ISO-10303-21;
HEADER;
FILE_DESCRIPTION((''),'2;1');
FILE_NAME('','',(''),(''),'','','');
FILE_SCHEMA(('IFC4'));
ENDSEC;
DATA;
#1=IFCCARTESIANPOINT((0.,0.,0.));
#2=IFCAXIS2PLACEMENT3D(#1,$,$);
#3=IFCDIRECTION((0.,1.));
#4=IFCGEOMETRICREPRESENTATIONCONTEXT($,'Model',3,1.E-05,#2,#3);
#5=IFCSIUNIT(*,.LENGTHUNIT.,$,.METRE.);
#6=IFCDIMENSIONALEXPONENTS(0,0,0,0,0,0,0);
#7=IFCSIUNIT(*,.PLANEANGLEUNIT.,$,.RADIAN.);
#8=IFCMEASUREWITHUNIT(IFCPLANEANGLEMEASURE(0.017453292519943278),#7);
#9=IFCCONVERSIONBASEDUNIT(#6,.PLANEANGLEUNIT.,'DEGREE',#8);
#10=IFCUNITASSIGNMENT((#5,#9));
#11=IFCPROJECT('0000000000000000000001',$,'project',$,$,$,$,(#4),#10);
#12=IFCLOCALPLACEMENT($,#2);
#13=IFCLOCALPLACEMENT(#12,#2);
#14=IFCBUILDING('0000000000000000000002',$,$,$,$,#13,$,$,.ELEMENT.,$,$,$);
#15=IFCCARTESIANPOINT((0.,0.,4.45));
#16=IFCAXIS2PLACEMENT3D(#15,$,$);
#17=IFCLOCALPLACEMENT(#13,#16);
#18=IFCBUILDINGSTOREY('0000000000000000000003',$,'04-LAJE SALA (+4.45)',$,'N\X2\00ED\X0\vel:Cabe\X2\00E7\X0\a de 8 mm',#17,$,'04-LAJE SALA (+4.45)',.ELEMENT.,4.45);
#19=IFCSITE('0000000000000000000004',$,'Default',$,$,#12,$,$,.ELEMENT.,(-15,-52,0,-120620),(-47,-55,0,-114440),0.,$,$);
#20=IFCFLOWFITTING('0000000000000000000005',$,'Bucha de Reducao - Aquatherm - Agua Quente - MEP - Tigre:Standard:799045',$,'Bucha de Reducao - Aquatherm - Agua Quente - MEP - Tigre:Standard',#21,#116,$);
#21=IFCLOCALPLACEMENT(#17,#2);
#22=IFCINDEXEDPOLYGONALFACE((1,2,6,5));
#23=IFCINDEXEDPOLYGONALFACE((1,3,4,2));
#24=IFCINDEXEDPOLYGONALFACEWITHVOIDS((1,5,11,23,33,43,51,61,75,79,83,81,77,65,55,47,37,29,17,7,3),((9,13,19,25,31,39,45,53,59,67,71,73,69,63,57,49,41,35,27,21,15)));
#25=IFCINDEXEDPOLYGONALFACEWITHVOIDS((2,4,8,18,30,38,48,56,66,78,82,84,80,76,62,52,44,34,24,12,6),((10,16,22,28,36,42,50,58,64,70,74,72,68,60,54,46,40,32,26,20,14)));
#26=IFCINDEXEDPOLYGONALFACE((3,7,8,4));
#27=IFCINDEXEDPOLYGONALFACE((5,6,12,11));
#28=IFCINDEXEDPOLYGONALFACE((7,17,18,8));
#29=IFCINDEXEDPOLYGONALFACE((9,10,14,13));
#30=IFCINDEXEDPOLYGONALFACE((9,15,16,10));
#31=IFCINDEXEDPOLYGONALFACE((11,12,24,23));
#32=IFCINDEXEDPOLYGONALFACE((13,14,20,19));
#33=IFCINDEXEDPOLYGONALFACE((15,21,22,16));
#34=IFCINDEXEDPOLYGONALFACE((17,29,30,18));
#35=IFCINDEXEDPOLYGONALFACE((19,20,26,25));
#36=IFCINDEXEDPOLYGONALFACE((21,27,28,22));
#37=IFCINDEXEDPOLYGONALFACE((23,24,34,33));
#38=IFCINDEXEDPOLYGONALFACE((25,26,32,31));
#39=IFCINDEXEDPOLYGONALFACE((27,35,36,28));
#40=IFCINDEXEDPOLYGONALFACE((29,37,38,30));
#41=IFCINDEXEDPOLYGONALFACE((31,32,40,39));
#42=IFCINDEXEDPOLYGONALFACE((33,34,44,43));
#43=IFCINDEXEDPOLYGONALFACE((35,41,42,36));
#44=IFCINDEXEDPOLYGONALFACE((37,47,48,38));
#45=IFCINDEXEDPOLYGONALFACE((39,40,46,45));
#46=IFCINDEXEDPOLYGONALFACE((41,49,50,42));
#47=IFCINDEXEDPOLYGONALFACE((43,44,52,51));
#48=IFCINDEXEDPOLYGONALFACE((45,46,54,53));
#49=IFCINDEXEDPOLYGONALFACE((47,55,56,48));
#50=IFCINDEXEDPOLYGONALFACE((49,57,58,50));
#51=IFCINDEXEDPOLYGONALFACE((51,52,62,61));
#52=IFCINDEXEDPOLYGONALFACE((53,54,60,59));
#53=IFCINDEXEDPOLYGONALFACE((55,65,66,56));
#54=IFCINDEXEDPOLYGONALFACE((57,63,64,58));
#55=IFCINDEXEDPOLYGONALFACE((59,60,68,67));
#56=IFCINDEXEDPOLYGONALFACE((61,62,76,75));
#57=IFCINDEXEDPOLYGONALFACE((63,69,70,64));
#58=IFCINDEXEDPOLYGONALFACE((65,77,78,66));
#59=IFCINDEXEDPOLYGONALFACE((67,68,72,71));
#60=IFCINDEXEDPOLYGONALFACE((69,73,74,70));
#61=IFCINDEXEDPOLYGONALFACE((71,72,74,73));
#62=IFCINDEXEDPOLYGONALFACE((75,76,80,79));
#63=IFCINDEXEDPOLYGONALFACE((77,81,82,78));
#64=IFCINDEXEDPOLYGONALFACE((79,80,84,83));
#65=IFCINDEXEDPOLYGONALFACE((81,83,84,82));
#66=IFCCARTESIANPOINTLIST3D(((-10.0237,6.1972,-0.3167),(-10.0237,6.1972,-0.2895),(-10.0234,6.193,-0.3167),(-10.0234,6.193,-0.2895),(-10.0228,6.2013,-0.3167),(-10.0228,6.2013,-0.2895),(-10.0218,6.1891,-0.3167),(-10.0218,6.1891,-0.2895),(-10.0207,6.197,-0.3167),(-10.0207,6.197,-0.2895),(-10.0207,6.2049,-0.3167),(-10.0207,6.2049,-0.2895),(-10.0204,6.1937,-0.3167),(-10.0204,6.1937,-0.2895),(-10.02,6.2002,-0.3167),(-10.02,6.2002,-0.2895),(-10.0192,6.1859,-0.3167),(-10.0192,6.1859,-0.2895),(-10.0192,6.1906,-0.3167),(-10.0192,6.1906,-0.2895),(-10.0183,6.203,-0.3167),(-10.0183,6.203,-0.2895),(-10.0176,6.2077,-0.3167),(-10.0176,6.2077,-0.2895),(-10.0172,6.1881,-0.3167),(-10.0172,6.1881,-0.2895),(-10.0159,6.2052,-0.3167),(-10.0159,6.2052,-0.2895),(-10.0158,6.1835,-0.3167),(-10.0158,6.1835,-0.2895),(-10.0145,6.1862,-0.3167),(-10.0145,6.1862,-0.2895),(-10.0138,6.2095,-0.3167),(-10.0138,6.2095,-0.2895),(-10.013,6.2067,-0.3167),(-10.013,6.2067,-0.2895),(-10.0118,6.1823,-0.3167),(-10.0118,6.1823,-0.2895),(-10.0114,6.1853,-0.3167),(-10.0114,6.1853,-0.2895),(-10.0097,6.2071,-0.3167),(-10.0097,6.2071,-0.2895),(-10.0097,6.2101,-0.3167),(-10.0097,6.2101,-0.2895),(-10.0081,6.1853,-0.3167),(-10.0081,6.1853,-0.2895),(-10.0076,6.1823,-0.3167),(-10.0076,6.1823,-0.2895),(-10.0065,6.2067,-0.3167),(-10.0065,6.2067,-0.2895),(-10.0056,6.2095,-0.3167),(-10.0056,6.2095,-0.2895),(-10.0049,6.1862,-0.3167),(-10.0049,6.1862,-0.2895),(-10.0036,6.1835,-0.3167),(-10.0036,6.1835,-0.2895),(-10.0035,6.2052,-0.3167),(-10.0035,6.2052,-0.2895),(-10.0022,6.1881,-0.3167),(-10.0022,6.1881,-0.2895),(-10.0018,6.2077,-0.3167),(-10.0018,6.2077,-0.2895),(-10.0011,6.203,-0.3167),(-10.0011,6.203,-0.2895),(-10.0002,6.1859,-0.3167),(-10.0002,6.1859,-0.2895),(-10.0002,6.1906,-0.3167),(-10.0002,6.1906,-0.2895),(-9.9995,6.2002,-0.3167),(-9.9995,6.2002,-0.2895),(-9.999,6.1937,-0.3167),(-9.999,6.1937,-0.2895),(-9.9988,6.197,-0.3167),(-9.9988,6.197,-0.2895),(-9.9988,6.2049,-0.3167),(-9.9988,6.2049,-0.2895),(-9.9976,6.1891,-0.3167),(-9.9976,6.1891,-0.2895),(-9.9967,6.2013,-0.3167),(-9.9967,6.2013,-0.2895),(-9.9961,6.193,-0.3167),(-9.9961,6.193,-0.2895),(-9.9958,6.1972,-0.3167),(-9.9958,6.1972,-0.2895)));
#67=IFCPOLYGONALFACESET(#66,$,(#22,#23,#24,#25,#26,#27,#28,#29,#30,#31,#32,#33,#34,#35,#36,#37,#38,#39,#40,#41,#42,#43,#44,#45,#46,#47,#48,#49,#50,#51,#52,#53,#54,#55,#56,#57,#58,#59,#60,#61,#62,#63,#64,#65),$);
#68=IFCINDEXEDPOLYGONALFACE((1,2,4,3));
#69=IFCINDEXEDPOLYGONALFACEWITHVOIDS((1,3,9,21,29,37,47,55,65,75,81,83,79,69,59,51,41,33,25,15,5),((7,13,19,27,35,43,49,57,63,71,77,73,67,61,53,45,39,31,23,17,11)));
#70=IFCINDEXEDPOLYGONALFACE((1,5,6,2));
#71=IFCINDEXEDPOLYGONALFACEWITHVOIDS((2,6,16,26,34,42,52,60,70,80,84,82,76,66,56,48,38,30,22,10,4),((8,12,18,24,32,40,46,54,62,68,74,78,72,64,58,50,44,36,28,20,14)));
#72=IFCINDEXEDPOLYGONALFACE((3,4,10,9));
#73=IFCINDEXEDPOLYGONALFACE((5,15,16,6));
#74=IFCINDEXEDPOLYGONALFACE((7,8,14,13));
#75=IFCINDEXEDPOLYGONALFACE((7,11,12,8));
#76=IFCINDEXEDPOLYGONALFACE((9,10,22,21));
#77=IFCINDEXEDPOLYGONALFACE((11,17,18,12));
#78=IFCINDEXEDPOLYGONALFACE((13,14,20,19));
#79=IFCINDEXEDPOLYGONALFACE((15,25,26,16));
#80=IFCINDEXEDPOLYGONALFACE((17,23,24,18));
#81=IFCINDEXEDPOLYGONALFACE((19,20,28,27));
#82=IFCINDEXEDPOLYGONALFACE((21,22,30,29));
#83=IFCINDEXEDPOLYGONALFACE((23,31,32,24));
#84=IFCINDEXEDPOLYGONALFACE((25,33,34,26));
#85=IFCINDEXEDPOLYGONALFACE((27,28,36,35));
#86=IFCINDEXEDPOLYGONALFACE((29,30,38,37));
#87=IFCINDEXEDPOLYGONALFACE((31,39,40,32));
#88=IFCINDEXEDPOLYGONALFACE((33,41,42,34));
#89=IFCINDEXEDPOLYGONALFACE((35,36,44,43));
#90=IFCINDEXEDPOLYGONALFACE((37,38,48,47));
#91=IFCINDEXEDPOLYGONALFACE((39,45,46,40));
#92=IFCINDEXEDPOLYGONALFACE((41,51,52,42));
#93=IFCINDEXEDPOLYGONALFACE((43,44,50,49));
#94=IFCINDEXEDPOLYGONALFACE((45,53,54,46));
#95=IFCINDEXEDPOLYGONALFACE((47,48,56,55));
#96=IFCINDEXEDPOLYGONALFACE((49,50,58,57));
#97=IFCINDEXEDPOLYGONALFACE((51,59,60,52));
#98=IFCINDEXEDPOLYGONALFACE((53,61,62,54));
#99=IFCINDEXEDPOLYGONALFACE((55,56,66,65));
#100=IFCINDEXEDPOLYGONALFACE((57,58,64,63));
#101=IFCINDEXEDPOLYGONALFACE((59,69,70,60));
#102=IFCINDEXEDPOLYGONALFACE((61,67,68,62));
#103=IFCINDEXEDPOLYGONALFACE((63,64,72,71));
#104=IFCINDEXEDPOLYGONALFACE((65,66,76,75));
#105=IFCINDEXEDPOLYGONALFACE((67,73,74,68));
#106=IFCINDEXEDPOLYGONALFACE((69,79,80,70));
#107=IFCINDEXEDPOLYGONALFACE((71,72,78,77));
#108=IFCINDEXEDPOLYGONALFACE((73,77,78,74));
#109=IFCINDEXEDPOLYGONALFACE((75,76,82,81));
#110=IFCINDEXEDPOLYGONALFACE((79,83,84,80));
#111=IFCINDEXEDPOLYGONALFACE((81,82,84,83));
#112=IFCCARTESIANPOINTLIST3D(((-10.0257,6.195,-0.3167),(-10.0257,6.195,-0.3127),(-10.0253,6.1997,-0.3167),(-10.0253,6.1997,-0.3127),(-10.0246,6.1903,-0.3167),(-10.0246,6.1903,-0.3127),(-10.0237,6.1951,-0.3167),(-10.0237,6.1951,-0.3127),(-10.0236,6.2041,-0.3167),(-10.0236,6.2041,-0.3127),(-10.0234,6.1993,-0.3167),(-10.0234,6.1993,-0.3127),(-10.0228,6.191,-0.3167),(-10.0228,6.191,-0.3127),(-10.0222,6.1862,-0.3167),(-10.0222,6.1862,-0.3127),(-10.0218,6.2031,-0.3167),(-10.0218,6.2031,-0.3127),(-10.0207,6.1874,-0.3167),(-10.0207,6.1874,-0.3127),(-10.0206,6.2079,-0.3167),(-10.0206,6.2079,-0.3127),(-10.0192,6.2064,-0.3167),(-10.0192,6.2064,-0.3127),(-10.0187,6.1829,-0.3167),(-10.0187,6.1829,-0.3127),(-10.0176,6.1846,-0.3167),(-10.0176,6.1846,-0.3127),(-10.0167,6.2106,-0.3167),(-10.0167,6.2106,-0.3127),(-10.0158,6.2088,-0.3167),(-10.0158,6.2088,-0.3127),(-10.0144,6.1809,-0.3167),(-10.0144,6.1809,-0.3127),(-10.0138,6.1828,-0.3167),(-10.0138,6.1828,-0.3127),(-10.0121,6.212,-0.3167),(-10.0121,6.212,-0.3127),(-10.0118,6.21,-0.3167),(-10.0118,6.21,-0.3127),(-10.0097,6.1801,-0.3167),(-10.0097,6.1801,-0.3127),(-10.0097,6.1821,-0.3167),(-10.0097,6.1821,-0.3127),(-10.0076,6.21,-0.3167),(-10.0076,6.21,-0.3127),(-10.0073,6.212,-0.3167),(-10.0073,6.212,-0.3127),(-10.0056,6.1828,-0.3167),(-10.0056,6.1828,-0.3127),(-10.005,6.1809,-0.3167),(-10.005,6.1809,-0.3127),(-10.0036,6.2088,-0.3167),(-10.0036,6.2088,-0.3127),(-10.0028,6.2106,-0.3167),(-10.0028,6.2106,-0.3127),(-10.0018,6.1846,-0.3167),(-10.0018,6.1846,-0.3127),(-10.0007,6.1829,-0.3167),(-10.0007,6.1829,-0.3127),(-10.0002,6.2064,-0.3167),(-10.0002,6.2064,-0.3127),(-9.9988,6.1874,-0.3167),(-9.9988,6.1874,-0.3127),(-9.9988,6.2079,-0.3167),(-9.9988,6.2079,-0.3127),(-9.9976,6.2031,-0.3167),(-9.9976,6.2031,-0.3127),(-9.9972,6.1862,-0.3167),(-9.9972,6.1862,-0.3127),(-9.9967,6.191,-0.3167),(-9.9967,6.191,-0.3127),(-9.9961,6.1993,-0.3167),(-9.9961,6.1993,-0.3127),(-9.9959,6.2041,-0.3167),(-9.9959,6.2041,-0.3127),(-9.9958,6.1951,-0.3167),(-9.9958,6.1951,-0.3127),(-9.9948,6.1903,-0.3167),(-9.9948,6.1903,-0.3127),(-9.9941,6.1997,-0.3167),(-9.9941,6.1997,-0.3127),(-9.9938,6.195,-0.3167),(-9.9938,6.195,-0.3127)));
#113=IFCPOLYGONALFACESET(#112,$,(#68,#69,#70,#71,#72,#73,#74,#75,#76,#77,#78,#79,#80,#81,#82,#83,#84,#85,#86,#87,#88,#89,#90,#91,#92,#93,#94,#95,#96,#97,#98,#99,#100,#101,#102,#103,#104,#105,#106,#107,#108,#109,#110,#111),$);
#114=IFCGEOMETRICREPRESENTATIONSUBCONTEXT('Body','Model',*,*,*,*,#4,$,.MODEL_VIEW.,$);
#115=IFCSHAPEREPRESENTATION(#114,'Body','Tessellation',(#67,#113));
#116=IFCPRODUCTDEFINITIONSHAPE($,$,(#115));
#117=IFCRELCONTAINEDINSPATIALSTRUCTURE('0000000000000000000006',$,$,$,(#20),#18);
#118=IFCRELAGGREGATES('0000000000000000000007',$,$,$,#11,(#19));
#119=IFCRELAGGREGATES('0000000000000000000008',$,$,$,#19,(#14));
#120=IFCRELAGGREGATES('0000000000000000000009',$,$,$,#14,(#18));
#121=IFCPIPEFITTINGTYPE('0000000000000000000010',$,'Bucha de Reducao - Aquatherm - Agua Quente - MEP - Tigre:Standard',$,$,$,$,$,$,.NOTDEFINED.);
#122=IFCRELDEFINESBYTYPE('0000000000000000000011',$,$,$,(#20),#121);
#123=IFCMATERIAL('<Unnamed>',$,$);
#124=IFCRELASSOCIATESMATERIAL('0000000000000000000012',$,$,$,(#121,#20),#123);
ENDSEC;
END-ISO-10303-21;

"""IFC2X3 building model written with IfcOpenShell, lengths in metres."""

from ifc_helpers import new_model, entity, si_unit, converted_unit, direction, frame, frame_2d, origin, place, context, subcontext, project, spatial, hollow_circle, extrude, source, transform, mapped, material, type_object, type_shapes, element, save


model = new_model("IFC2X3")

# Units and contexts
model_context = context("Model", 3, precision=1e-05, world=origin(), true_north=direction((0.0, 1.0)))
body_context = subcontext(model_context, "Body", "Model", "MODEL_VIEW")
ifc_project = project(units=[si_unit("LENGTHUNIT", "METRE"), converted_unit("PLANEANGLEUNIT", "DEGREE", entity("IfcPlaneAngleMeasure", 0.017453292519943278), si_unit("PLANEANGLEUNIT", "RADIAN"), dimensions=[0, 0, 0, 0, 0, 0, 0])], contexts=[model_context])

# Site, building, storey
site_placement = place(None, origin())
site = spatial("IfcSite", under=ifc_project, at=site_placement, Name="Default", CompositionType="ELEMENT", RefLatitude=(-15, -52, 0, -120620), RefLongitude=(-47, -55, 0, -114440), RefElevation=0.0)
building_placement = place(site_placement, origin())
building = spatial("IfcBuilding", under=site, at=building_placement, CompositionType="ELEMENT")
storey_placement = place(building_placement, frame((0.0, 0.0, 4.45)))
storey = spatial("IfcBuildingStorey", under=building, at=storey_placement, Name="04-LAJE SALA (+4.45)", ObjectType="Nível:Cabeça de 8 mm", LongName="04-LAJE SALA (+4.45)", CompositionType="ELEMENT", Elevation=4.45)

# Flow fitting
ifc_material_1 = material(Name="<Unnamed>")
pipe_fitting_type_1 = type_object("IfcPipeFittingType", Name="Bucha de Reducao - Aquatherm - Agua Quente - MEP - Tigre:Standard", PredefinedType="NOTDEFINED", material=ifc_material_1)
shared_shape_1 = source(origin(), body_context, "Body", "SweptSolid", [
    extrude(hollow_circle(Radius=0.014, WallThickness=0.003, at=frame_2d((0.0, 0.0), x_axis=(1.0, 0.0))), frame((0.0, 0.0, 0.0), z_axis=(1.0, 0.0, 0.0), x_axis=(0.0, -1.0, 0.0)), (0.0, 0.0, 1.0), 0.0272),
    extrude(hollow_circle(Radius=0.016, WallThickness=0.002, at=frame_2d((0.0, 0.0), x_axis=(1.0, 0.0))), frame((0.0232, 0.0, 0.0), z_axis=(1.0, 0.0, 0.0), x_axis=(0.0, 1.0, 0.0)), (0.0, 0.0, 1.0), 0.004),
])
type_shapes(pipe_fitting_type_1, [shared_shape_1])
flow_fitting_1_placement = place(storey_placement, frame((-10.0097, 6.1961, -0.2895), z_axis=(-1.0, 0.0, 0.0), x_axis=(0.0, 0.0, -1.0)))
element("IfcFlowFitting", 1, at=flow_fitting_1_placement, inside=storey, type_object=pipe_fitting_type_1, material=ifc_material_1, Name="Bucha de Reducao - Aquatherm - Agua Quente - MEP - Tigre:Standard:799045", ObjectType="Bucha de Reducao - Aquatherm - Agua Quente - MEP - Tigre:Standard", context=body_context, shape_type="MappedRepresentation", body=[
    mapped(shared_shape_1, transform((0.0, 0.0, 0.0), scale=1.0)),
])

save(model, "model.ifc")
